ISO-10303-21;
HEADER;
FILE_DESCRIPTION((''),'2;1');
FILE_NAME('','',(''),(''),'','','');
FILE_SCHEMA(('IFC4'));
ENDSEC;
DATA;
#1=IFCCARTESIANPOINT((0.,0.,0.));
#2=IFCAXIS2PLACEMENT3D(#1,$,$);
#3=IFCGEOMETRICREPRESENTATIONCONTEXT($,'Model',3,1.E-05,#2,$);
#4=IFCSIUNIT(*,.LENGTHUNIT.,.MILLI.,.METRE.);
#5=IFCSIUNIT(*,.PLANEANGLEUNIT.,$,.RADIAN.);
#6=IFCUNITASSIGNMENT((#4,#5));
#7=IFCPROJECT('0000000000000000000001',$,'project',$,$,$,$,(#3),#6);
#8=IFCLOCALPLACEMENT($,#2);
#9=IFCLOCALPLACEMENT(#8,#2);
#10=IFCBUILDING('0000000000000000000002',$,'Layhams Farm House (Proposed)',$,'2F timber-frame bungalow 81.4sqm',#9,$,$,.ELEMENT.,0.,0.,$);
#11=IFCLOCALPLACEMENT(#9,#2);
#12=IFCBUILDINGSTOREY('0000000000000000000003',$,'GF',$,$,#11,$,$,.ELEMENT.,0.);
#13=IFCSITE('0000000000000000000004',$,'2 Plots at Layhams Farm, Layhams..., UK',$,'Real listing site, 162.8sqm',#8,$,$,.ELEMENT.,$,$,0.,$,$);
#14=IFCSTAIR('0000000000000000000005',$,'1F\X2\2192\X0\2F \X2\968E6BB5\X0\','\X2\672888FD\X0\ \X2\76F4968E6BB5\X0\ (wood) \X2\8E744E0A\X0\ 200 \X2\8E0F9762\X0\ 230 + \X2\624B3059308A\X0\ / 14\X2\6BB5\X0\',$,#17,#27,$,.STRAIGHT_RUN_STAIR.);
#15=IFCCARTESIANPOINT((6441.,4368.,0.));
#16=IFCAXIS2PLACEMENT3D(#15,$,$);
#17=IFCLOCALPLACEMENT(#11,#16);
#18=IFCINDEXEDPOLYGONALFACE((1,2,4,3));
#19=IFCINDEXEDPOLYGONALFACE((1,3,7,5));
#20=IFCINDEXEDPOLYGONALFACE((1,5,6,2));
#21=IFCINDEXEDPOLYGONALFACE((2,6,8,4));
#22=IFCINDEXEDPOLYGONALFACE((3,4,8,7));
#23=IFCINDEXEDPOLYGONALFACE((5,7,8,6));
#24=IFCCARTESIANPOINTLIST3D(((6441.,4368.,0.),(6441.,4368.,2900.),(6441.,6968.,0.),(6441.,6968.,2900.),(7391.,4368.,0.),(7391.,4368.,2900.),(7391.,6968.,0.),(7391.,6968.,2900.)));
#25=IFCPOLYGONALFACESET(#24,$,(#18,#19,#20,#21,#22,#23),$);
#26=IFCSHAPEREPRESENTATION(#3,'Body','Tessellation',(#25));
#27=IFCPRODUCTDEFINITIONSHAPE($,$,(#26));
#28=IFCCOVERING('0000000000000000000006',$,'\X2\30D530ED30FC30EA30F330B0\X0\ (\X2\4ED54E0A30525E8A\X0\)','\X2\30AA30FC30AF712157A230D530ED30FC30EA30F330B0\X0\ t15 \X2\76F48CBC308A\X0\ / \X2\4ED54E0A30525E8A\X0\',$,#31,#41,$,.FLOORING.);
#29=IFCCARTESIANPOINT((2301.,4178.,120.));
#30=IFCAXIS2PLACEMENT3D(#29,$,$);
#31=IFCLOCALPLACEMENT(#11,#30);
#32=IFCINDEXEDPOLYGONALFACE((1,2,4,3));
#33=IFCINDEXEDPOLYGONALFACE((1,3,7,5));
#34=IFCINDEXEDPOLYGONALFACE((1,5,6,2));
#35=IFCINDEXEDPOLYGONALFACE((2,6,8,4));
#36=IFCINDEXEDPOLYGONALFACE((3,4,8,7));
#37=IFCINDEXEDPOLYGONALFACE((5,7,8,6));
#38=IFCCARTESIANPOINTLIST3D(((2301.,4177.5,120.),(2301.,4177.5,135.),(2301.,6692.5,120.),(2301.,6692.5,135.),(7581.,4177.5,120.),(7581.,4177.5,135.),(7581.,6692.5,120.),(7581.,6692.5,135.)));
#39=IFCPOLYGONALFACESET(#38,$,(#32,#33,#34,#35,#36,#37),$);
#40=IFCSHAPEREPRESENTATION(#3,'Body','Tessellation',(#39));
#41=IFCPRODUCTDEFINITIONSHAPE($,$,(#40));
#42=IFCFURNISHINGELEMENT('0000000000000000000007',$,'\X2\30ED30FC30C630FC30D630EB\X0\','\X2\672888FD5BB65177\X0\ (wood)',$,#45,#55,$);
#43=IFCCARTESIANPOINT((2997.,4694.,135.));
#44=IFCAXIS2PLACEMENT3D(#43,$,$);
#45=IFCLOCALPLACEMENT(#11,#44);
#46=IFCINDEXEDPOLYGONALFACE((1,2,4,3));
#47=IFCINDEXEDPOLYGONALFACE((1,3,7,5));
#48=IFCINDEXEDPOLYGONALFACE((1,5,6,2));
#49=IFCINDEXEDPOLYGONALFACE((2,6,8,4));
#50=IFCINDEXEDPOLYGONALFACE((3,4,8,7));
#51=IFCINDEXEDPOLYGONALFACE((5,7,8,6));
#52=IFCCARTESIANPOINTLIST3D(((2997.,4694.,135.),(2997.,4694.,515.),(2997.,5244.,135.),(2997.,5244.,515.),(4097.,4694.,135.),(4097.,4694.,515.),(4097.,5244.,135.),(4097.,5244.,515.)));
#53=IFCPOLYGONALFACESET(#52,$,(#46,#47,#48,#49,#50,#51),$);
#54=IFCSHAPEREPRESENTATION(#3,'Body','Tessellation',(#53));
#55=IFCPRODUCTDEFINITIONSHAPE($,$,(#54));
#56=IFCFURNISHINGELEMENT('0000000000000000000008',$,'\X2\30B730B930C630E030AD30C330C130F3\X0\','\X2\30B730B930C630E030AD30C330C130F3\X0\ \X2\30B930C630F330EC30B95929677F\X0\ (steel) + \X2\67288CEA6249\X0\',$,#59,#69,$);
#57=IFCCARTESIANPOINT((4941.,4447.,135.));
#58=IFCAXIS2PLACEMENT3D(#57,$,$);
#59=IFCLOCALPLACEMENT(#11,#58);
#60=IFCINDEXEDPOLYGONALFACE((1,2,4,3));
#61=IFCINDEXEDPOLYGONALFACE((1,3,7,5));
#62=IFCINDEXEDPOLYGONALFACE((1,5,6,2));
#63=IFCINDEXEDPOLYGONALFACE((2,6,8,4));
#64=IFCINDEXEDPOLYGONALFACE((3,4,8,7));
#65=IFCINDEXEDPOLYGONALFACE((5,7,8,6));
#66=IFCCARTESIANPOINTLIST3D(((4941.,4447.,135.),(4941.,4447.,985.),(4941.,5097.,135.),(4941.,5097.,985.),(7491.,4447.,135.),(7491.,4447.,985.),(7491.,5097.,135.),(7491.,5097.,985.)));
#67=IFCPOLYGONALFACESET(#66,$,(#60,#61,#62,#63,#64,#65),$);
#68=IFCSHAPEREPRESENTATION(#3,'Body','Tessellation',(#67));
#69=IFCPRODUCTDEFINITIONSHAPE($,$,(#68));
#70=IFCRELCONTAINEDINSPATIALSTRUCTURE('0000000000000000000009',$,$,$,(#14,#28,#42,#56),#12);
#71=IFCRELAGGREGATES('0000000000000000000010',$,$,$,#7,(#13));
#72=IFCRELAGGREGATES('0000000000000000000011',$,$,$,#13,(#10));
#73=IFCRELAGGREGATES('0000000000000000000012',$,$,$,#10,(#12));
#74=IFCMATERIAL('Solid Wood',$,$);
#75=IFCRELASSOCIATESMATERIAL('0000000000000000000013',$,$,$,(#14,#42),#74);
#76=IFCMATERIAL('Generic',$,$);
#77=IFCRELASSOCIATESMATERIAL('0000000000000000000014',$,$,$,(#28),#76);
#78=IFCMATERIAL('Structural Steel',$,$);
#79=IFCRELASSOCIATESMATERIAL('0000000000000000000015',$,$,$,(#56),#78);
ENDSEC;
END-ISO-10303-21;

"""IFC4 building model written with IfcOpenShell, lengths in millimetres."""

from ifc_helpers import new_model, si_unit, frame, frame_2d, origin, place, context, project, spatial, rectangle, extrude, material, element, save


model = new_model("IFC4")

# Units and contexts
model_context = context("Model", 3, precision=1e-05, world=origin())
ifc_project = project(units=[si_unit("LENGTHUNIT", "METRE", prefix="MILLI"), si_unit("PLANEANGLEUNIT", "RADIAN")], contexts=[model_context])

# Site, building, storey
site_placement = place(None, origin())
site = spatial("IfcSite", under=ifc_project, at=site_placement, Name="2 Plots at Layhams Farm, Layhams..., UK", ObjectType="Real listing site, 162.8sqm", CompositionType="ELEMENT", RefElevation=0.0)
building_placement = place(site_placement, origin())
building = spatial("IfcBuilding", under=site, at=building_placement, Name="Layhams Farm House (Proposed)", ObjectType="2F timber-frame bungalow 81.4sqm", CompositionType="ELEMENT", ElevationOfRefHeight=0.0, ElevationOfTerrain=0.0)
storey_placement = place(building_placement, origin())
storey = spatial("IfcBuildingStorey", under=building, at=storey_placement, Name="GF", CompositionType="ELEMENT", Elevation=0.0)

# Shared definitions
ifc_material_1 = material(Name="Solid Wood")

# Stair
stair_placement = place(storey_placement, frame((6441.0, 4368.0, 0.0)))
element("IfcStair", 1, at=stair_placement, inside=storey, material=ifc_material_1, Name="1F→2F 階段", Description="木製 直階段 (wood) 蹴上 200 踏面 230 + 手すり / 14段", PredefinedType="STRAIGHT_RUN_STAIR", context=model_context, shape_type="SweptSolid", body=[
    extrude(rectangle(XDim=950.0, YDim=2600.0, at=frame_2d((475.0, 1300.0))), frame((6441.0, 4368.0, 0.0)), (0.0, 0.0, 1.0), 2900.0),
])

# Covering
ifc_material_2 = material(Name="Generic")
covering_placement = place(storey_placement, frame((2301.0, 4178.0, 120.0)))
element("IfcCovering", 2, at=covering_placement, inside=storey, material=ifc_material_2, Name="フローリング (仕上げ床)", Description="オーク無垢フローリング t15 直貼り / 仕上げ床", PredefinedType="FLOORING", context=model_context, shape_type="SweptSolid", body=[
    extrude(rectangle(XDim=5280.0, YDim=2515.0, at=frame_2d((2640.0, 1257.0))), frame((2301.0, 4178.0, 120.0)), (0.0, 0.0, 1.0), 15.0),
])

# Furnishing elements
furnishing_1_placement = place(storey_placement, frame((2997.0, 4694.0, 135.0)))
element("IfcFurnishingElement", 3, at=furnishing_1_placement, inside=storey, material=ifc_material_1, Name="ローテーブル", Description="木製家具 (wood)", context=model_context, shape_type="SweptSolid", body=[
    extrude(rectangle(XDim=1100.0, YDim=550.0, at=frame_2d((550.0, 275.0))), frame((2997.0, 4694.0, 135.0)), (0.0, 0.0, 1.0), 380.0),
])
ifc_material_3 = material(Name="Structural Steel")
furnishing_2_placement = place(storey_placement, frame((4941.0, 4447.0, 135.0)))
element("IfcFurnishingElement", 4, at=furnishing_2_placement, inside=storey, material=ifc_material_3, Name="システムキッチン", Description="システムキッチン ステンレス天板 (steel) + 木質扉", context=model_context, shape_type="SweptSolid", body=[
    extrude(rectangle(XDim=2550.0, YDim=650.0, at=frame_2d((1275.0, 325.0))), frame((4941.0, 4447.0, 135.0)), (0.0, 0.0, 1.0), 850.0),
])

save(model, "model.ifc")
